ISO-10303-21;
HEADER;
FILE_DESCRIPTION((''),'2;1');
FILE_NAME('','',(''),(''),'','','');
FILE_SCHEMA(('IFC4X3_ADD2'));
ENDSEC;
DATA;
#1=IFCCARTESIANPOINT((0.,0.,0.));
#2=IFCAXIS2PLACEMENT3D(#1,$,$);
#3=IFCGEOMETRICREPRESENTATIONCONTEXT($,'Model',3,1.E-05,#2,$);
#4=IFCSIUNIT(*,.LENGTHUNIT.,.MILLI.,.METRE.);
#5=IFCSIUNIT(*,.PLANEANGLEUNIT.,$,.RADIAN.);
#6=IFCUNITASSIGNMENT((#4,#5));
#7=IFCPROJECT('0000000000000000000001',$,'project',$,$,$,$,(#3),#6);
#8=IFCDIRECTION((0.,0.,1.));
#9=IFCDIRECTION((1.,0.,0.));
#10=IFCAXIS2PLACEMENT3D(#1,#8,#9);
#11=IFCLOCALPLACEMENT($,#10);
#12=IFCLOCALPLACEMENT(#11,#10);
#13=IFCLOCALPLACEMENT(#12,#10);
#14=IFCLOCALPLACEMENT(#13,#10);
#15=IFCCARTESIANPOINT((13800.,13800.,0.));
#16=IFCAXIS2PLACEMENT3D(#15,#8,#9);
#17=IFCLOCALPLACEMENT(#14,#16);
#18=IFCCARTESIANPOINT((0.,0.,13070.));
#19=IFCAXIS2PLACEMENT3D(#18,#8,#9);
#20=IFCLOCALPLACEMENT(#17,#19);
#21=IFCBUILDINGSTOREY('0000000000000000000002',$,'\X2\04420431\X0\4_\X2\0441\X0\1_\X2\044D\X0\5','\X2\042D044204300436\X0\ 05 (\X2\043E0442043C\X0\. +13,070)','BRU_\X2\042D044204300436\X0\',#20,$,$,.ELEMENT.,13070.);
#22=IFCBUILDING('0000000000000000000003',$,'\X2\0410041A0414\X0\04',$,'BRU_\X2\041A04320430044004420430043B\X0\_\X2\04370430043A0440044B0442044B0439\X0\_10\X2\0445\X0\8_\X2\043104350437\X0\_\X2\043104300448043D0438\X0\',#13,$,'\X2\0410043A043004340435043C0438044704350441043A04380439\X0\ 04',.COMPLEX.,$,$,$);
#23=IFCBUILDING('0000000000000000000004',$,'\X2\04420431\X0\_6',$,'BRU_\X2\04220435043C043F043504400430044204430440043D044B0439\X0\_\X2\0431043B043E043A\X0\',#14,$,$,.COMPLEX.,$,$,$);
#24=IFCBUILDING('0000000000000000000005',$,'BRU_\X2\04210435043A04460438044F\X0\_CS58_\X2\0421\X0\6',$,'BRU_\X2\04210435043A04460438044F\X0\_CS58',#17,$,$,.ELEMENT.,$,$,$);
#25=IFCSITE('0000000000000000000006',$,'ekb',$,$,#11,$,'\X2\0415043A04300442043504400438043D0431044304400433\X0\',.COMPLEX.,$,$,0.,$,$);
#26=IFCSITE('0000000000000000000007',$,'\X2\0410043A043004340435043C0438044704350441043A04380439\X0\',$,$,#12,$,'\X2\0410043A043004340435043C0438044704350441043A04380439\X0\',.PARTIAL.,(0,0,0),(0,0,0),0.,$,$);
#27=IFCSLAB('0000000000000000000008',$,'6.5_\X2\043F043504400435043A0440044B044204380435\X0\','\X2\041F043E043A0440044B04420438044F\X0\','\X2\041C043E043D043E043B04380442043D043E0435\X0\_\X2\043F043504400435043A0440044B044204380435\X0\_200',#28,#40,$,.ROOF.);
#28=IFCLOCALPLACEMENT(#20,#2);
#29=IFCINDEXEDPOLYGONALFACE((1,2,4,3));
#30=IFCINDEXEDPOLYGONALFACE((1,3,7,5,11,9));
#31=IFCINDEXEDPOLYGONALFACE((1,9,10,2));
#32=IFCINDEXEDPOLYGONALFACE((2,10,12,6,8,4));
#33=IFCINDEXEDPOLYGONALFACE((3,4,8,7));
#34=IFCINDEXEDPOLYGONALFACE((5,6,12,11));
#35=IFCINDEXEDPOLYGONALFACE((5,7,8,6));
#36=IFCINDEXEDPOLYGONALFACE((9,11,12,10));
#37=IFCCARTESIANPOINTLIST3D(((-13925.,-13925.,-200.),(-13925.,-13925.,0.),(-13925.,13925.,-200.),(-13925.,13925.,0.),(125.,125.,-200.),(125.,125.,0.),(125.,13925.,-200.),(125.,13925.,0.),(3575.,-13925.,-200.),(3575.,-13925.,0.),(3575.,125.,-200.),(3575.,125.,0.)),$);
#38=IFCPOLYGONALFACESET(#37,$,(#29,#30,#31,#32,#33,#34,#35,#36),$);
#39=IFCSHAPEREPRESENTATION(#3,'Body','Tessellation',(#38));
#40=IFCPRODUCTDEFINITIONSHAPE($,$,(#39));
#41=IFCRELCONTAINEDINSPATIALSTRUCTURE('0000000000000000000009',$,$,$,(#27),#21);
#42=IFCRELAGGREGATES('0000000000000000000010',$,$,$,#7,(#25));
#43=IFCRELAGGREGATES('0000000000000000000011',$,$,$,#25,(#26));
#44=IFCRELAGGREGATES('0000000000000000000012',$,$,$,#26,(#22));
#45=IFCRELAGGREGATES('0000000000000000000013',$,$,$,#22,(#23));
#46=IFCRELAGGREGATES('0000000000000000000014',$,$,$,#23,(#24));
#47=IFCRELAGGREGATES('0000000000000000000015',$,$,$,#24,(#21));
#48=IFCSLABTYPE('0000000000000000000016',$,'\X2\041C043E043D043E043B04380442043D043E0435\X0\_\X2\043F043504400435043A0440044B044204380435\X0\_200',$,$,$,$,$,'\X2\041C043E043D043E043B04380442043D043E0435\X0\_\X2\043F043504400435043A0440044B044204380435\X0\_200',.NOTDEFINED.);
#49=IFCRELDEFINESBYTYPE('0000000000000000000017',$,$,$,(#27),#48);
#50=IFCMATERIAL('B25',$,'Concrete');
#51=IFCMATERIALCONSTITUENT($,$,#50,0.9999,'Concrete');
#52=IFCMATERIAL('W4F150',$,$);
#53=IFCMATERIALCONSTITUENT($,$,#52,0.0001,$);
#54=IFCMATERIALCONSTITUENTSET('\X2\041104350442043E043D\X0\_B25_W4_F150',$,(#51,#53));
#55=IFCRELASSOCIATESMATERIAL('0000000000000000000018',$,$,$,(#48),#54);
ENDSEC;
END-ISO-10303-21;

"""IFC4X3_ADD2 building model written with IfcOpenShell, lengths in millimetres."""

from ifc_helpers import new_model, si_unit, frame, origin, origin_with_axes, place, context, project, spatial, polyline, outline, extrude, material, constituent, constituent_set, type_object, element, save


model = new_model("IFC4X3_ADD2")

# Units and contexts
model_context = context("Model", 3, precision=1e-05, world=origin())
ifc_project = project(units=[si_unit("LENGTHUNIT", "METRE", prefix="MILLI"), si_unit("PLANEANGLEUNIT", "RADIAN")], contexts=[model_context])

# Sites, buildings, storey
site_1_placement = place(None, origin_with_axes())
site_1 = spatial("IfcSite", under=ifc_project, at=site_1_placement, Name="ekb", LongName="Екатеринбург", CompositionType="COMPLEX", RefElevation=0.0)
site_2_placement = place(site_1_placement, origin_with_axes())
site_2 = spatial("IfcSite", under=site_1, at=site_2_placement, Name="Академический", LongName="Академический", CompositionType="PARTIAL", RefLatitude=(0, 0, 0), RefLongitude=(0, 0, 0), RefElevation=0.0)
building_1_placement = place(site_2_placement, origin_with_axes())
building_1 = spatial("IfcBuilding", under=site_2, at=building_1_placement, Name="АКД04", ObjectType="BRU_Квартал_закрытый_10х8_без_башни", LongName="Академический 04", CompositionType="COMPLEX")
building_2_placement = place(building_1_placement, origin_with_axes())
building_2 = spatial("IfcBuilding", under=building_1, at=building_2_placement, Name="тб_6", ObjectType="BRU_Температурный_блок", CompositionType="COMPLEX")
building_3_placement = place(building_2_placement, frame((13800.0, 13800.0, 0.0), z_axis=(0.0, 0.0, 1.0), x_axis=(1.0, 0.0, 0.0)))
building_3 = spatial("IfcBuilding", under=building_2, at=building_3_placement, Name="BRU_Секция_CS58_С6", ObjectType="BRU_Секция_CS58", CompositionType="ELEMENT")
storey_placement = place(building_3_placement, frame((0.0, 0.0, 13070.0), z_axis=(0.0, 0.0, 1.0), x_axis=(1.0, 0.0, 0.0)))
storey = spatial("IfcBuildingStorey", under=building_3, at=storey_placement, Name="тб4_с1_э5", Description="Этаж 05 (отм. +13,070)", ObjectType="BRU_Этаж", CompositionType="ELEMENT", Elevation=13070.0)

# Shared definitions
ifc_material_1 = material(Name="B25", Category="Concrete")
ifc_material_2 = material(Name="W4F150")

# Slab
ifc_constituent_1 = constituent(ifc_material_1, Category="Concrete", fraction=0.9999)
ifc_constituent_2 = constituent(ifc_material_2, fraction=0.0001)
ifc_constituent_set_1 = constituent_set(constituents=[ifc_constituent_1, ifc_constituent_2], Name="Бетон_B25_W4_F150")
slab_type = type_object("IfcSlabType", Name="Монолитное_перекрытие_200", ElementType="Монолитное_перекрытие_200", PredefinedType="NOTDEFINED", material=ifc_constituent_set_1)
slab_placement = place(storey_placement, frame((0.0, 0.0, -200.0), z_axis=(0.0, 0.0, 1.0), x_axis=(1.0, 0.0, 0.0)))
element("IfcSlab", 1, at=slab_placement, inside=storey, type_object=slab_type, Name="6.5_перекрытие", Description="Покрытия", ObjectType="Монолитное_перекрытие_200", PredefinedType="ROOF", context=model_context, shape_type="SweptSolid", body=[
    extrude(outline(polyline([(-13925.0, -13925.0), (3575.0, -13925.0), (3575.0, 125.0), (125.0, 125.0), (125.0, 13925.0), (-13925.0, 13925.0), (-13925.0, -13925.0)])), origin_with_axes(), (0.0, 0.0, 1.0), 200.0),
])

save(model, "model.ifc")
